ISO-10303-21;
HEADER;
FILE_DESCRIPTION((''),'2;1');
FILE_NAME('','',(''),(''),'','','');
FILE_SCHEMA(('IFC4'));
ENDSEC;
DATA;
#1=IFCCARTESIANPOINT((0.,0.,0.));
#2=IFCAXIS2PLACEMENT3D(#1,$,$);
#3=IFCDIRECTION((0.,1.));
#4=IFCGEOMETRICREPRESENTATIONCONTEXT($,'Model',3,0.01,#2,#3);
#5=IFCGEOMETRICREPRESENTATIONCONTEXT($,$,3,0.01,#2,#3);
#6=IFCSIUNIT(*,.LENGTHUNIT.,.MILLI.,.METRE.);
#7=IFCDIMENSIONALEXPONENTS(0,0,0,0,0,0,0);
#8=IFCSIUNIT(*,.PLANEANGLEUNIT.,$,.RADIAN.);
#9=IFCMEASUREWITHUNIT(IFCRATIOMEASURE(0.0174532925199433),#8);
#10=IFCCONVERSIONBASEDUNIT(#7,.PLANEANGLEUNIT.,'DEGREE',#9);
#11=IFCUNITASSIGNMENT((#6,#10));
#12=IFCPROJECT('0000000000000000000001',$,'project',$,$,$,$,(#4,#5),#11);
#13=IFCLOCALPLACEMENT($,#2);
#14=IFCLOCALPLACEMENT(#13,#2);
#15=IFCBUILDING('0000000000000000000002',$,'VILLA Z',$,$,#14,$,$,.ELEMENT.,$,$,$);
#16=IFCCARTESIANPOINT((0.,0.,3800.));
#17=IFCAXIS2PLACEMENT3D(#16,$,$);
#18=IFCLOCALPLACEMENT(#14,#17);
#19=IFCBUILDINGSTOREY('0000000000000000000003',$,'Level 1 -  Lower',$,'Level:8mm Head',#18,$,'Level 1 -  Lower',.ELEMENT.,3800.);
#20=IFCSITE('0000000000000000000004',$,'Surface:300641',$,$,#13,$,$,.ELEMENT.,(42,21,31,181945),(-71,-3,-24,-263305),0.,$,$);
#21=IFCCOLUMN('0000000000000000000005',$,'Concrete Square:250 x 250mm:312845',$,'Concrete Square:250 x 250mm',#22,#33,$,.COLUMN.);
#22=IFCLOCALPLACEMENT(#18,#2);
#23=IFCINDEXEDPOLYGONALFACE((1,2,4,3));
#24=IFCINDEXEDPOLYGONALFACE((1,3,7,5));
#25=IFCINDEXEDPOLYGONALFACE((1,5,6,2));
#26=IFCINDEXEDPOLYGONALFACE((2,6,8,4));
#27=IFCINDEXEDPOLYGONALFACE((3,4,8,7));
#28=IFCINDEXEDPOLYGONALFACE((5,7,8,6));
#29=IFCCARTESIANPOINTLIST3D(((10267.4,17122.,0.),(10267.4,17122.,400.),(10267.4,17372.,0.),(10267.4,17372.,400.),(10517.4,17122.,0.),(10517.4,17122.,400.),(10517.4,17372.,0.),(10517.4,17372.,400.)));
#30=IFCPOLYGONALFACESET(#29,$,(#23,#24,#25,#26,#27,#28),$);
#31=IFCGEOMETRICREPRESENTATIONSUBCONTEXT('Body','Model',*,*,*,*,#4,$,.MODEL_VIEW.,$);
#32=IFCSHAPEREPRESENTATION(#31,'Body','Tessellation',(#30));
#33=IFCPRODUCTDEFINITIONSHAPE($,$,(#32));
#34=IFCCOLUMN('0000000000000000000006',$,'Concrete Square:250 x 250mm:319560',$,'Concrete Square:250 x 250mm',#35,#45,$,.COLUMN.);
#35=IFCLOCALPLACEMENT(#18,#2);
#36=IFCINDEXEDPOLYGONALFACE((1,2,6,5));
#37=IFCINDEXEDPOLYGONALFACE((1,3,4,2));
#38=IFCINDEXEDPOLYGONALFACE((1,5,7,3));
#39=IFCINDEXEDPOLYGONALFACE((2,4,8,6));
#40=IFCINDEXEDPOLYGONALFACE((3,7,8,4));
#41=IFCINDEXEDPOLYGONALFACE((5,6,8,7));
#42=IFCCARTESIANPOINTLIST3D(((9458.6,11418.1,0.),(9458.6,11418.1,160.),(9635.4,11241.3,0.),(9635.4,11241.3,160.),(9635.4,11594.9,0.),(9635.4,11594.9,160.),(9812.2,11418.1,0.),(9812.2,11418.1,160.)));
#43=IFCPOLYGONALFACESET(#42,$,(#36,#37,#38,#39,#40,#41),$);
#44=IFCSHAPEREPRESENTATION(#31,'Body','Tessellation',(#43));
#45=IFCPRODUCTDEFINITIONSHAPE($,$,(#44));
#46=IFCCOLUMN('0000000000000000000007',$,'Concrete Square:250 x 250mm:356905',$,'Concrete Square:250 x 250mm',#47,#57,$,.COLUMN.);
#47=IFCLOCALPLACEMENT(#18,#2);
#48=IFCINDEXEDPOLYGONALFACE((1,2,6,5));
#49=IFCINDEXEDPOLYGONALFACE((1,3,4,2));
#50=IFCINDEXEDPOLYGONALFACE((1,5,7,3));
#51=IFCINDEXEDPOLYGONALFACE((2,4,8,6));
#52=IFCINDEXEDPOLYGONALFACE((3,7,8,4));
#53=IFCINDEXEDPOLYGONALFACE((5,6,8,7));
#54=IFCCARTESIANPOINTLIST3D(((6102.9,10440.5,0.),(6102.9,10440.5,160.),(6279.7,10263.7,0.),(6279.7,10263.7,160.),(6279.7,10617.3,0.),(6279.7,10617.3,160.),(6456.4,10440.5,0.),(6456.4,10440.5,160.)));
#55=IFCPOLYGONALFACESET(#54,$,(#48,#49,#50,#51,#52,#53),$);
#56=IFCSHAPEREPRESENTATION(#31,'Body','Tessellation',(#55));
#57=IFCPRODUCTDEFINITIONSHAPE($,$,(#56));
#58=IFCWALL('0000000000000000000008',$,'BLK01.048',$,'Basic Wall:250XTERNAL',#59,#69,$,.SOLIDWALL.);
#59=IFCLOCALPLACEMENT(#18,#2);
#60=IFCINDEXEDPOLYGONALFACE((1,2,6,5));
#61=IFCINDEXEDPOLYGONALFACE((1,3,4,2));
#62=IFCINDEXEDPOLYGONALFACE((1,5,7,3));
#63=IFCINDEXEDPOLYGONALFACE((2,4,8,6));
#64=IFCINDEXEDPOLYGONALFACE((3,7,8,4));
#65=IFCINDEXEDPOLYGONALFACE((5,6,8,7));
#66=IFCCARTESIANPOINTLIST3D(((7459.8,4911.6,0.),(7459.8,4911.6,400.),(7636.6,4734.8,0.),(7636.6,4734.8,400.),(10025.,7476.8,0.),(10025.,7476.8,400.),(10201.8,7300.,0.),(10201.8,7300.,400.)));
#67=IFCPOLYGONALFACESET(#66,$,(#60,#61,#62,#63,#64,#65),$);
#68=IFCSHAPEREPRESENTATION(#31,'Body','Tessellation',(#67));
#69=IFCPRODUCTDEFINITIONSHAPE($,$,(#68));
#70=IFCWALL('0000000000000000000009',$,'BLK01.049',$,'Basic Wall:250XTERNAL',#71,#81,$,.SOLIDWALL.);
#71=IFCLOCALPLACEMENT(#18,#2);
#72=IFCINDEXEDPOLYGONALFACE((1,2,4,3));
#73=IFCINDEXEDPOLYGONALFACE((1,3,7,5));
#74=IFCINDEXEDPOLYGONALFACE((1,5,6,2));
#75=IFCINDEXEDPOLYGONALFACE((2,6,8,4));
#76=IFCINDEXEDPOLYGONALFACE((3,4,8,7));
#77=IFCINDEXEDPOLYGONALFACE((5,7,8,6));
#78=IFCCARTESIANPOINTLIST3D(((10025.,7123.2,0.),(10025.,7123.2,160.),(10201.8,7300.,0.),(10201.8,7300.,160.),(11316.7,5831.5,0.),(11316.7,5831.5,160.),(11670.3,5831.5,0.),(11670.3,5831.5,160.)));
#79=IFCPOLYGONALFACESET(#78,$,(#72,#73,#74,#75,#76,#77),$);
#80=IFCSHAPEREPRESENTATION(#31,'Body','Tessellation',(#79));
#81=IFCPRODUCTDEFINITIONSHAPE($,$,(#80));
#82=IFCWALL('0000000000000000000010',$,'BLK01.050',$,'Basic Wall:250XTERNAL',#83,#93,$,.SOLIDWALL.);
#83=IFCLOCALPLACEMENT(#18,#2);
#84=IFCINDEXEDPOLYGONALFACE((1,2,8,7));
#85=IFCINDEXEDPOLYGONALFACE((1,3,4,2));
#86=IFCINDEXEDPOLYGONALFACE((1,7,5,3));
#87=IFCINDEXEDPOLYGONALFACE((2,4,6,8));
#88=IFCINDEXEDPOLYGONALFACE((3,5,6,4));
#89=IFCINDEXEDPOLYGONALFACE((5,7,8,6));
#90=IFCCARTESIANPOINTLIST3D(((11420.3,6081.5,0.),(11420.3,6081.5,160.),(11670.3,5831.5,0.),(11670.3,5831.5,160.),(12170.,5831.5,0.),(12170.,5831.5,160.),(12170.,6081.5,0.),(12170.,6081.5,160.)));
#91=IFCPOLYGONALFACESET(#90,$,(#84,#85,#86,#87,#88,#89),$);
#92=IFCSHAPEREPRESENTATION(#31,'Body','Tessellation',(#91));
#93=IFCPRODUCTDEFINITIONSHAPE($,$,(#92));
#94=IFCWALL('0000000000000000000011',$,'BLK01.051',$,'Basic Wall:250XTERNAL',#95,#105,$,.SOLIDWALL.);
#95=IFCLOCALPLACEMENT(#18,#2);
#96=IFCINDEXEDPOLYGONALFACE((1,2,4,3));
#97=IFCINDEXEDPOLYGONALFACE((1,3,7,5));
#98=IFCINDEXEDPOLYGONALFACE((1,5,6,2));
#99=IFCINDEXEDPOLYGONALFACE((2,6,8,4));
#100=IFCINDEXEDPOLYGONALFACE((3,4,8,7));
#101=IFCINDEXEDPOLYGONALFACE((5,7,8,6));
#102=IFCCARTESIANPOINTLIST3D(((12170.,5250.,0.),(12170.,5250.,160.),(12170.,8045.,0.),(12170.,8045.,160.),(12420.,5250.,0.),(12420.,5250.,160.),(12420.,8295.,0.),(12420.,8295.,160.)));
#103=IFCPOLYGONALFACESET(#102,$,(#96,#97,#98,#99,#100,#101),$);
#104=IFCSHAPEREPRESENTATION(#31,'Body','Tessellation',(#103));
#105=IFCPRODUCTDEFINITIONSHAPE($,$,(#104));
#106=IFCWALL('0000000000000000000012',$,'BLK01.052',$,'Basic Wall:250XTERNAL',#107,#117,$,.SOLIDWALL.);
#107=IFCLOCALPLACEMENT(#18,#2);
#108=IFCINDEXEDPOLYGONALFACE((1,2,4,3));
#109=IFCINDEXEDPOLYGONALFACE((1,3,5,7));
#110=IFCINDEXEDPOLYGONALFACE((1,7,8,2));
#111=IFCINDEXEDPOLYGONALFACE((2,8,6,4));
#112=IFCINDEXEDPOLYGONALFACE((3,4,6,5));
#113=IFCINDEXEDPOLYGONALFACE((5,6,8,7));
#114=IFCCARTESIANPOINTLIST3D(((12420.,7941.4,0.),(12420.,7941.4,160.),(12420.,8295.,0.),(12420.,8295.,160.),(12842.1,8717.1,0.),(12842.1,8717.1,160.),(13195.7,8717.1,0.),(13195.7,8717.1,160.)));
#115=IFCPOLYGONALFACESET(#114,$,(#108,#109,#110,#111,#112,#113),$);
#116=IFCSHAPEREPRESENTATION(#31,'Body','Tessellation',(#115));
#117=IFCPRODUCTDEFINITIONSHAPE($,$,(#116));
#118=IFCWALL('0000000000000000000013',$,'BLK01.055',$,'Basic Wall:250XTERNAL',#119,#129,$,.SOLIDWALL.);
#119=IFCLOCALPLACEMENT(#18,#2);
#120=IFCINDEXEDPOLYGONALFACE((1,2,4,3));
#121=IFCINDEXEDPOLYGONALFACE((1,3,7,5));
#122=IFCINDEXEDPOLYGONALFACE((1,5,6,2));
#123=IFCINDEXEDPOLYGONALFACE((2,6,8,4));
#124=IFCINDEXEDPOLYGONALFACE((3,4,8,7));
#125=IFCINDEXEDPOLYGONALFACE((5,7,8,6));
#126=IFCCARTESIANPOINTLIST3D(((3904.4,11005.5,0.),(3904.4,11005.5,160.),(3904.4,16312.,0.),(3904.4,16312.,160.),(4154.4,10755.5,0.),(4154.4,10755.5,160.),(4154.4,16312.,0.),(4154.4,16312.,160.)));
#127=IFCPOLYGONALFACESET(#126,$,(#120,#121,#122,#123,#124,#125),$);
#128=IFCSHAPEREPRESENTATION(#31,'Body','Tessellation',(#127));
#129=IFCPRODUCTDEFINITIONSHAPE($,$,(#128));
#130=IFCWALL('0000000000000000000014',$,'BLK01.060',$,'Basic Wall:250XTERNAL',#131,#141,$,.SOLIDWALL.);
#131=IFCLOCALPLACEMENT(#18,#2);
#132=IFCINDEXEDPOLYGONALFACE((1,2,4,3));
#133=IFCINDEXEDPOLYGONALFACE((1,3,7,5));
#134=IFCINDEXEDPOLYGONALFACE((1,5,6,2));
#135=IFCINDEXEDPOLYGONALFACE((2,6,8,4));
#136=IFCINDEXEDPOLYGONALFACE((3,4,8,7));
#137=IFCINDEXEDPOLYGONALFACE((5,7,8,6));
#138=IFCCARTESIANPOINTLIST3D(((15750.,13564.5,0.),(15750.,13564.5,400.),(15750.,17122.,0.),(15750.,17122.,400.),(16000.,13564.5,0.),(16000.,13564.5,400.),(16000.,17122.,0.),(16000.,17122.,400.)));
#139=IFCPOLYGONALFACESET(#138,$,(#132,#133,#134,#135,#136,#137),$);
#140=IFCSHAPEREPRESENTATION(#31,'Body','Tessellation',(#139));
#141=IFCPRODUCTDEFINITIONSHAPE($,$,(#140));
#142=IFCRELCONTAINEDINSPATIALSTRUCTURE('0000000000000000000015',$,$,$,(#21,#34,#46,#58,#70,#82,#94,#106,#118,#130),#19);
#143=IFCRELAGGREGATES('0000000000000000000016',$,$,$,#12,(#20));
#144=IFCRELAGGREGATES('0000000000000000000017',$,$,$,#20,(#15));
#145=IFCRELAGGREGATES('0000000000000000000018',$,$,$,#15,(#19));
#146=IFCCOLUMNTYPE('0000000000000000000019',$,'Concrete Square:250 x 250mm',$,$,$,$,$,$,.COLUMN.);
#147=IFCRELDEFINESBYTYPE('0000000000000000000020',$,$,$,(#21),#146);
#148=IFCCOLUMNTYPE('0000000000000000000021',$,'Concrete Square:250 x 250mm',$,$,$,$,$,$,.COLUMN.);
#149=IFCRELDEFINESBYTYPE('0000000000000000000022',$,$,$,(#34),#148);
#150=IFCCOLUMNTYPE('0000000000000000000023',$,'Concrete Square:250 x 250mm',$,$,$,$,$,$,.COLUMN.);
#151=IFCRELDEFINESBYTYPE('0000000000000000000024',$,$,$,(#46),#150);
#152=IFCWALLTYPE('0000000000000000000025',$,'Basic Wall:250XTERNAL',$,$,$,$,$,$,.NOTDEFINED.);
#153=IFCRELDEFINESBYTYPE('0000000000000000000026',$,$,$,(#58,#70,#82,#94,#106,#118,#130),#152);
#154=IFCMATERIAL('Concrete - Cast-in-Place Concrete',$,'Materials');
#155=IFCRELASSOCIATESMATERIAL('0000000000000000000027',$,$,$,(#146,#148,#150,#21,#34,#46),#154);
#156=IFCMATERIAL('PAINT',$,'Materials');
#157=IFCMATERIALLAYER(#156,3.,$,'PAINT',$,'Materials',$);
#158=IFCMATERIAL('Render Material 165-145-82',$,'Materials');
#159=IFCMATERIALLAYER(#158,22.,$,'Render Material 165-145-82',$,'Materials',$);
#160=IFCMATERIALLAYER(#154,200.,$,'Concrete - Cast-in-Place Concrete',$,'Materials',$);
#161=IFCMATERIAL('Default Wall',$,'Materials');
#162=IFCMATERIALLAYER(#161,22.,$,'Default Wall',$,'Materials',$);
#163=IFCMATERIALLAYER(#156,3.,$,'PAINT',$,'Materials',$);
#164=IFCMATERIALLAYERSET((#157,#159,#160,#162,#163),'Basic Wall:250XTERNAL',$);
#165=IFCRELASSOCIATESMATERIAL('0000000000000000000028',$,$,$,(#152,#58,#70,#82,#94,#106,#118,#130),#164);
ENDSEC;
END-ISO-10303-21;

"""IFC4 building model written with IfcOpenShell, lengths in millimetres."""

from ifc_helpers import new_model, entity, si_unit, converted_unit, direction, frame, frame_2d, origin, origin_2d_with_axis, place, context, subcontext, project, spatial, polyline, rectangle, outline, extrude, clip, halfspace, bounded_halfspace, source, transform, mapped, material, layer, layer_set, layer_usage, material_profile, profile_set, profile_usage, type_object, type_shapes, element, save


model = new_model("IFC4")

# Units and contexts
model_context = context("Model", 3, precision=0.01, world=origin(), true_north=direction((0.0, 1.0)))
context_of_model = context(None, 3, precision=0.01, world=origin(), true_north=direction((0.0, 1.0)))
body_context = subcontext(model_context, "Body", "Model", "MODEL_VIEW")
ifc_project = project(units=[si_unit("LENGTHUNIT", "METRE", prefix="MILLI"), converted_unit("PLANEANGLEUNIT", "DEGREE", entity("IfcRatioMeasure", 0.0174532925199433), si_unit("PLANEANGLEUNIT", "RADIAN"), dimensions=[0, 0, 0, 0, 0, 0, 0])], contexts=[model_context, context_of_model])

# Site, building, storey
site_placement = place(None, origin())
site = spatial("IfcSite", under=ifc_project, at=site_placement, Name="Surface:300641", CompositionType="ELEMENT", RefLatitude=(42, 21, 31, 181945), RefLongitude=(-71, -3, -24, -263305), RefElevation=0.0)
building_placement = place(site_placement, origin())
building = spatial("IfcBuilding", under=site, at=building_placement, Name="VILLA Z", CompositionType="ELEMENT")
storey_placement = place(building_placement, frame((0.0, 0.0, 3800.0)))
storey = spatial("IfcBuildingStorey", under=building, at=storey_placement, Name="Level 1 -  Lower", ObjectType="Level:8mm Head", LongName="Level 1 -  Lower", CompositionType="ELEMENT", Elevation=3800.0)

# Columns
ifc_material_1 = material(Name="Concrete - Cast-in-Place Concrete", Category="Materials")
ifc_material_profile_1 = material_profile(ifc_material_1, rectangle(XDim=250.0, YDim=250.0, at=frame_2d((0.0, 0.0), x_axis=(1.0, 0.0))), Name="250 x 250mm")
ifc_profile_set_1 = profile_set([ifc_material_profile_1], Name="250 x 250mm")
ifc_profile_usage_1 = profile_usage(ifc_profile_set_1)
column_type_1 = type_object("IfcColumnType", Name="Concrete Square:250 x 250mm", PredefinedType="COLUMN", material=ifc_profile_set_1)
shared_shape_1 = source(origin(), body_context, "Body", "SweptSolid", [
    extrude(rectangle(XDim=250.0, YDim=250.0, at=origin_2d_with_axis()), frame((10392.4, 17247.0, 3800.0), z_axis=(0.0, 0.0, 1.0), x_axis=(0.0, -1.0, 0.0)), (0.0, 0.0, 1.0), 400.0),
])
type_shapes(column_type_1, [shared_shape_1])
column_1_placement = place(storey_placement, frame((0.0, 0.0, -3800.0)))
element("IfcColumn", 1, at=column_1_placement, inside=storey, type_object=column_type_1, material=ifc_profile_usage_1, Name="Concrete Square:250 x 250mm:312845", ObjectType="Concrete Square:250 x 250mm", PredefinedType="COLUMN", context=body_context, shape_type="MappedRepresentation", body=[
    mapped(shared_shape_1, transform((0.0, 0.0, 0.0), scale=1.0)),
])
ifc_profile_usage_2 = profile_usage(ifc_profile_set_1)
column_type_2 = type_object("IfcColumnType", Name="Concrete Square:250 x 250mm", PredefinedType="COLUMN", material=ifc_profile_set_1)
shared_shape_2 = source(origin(), body_context, "Body", "SweptSolid", [
    extrude(rectangle(XDim=250.0, YDim=250.0, at=frame_2d((0.0, 0.0), x_axis=(1.0, 0.0))), frame((9635.4, 11418.1, 3800.0), z_axis=(0.0, 0.0, 1.0), x_axis=(-0.707107, 0.707107, 0.0)), (0.0, 0.0, 1.0), 160.0),
])
type_shapes(column_type_2, [shared_shape_2])
column_2_placement = place(storey_placement, frame((0.0, 0.0, -3800.0)))
element("IfcColumn", 2, at=column_2_placement, inside=storey, type_object=column_type_2, material=ifc_profile_usage_2, Name="Concrete Square:250 x 250mm:319560", ObjectType="Concrete Square:250 x 250mm", PredefinedType="COLUMN", context=body_context, shape_type="MappedRepresentation", body=[
    mapped(shared_shape_2, transform((0.0, 0.0, 0.0), scale=1.0)),
])
ifc_profile_usage_3 = profile_usage(ifc_profile_set_1)
column_type_3 = type_object("IfcColumnType", Name="Concrete Square:250 x 250mm", PredefinedType="COLUMN", material=ifc_profile_set_1)
shared_shape_3 = source(origin(), body_context, "Body", "SweptSolid", [
    extrude(rectangle(XDim=250.0, YDim=250.0, at=origin_2d_with_axis()), frame((6279.7, 10440.5, 3800.0), z_axis=(0.0, 0.0, 1.0), x_axis=(-0.707107, 0.707107, 0.0)), (0.0, 0.0, 1.0), 160.0),
])
type_shapes(column_type_3, [shared_shape_3])
column_3_placement = place(storey_placement, frame((0.0, 0.0, -3800.0)))
element("IfcColumn", 3, at=column_3_placement, inside=storey, type_object=column_type_3, material=ifc_profile_usage_3, Name="Concrete Square:250 x 250mm:356905", ObjectType="Concrete Square:250 x 250mm", PredefinedType="COLUMN", context=body_context, shape_type="MappedRepresentation", body=[
    mapped(shared_shape_3, transform((0.0, 0.0, 0.0), scale=1.0)),
])

# Walls
ifc_material_2 = material(Name="PAINT", Category="Materials")
ifc_layer_1 = layer(ifc_material_2, 3.0, Name="PAINT", Category="Materials")
ifc_material_3 = material(Name="Render Material 165-145-82", Category="Materials")
ifc_layer_2 = layer(ifc_material_3, 22.0, Name="Render Material 165-145-82", Category="Materials")
ifc_layer_3 = layer(ifc_material_1, 200.0, Name="Concrete - Cast-in-Place Concrete", Category="Materials")
ifc_material_4 = material(Name="Default Wall", Category="Materials")
ifc_layer_4 = layer(ifc_material_4, 22.0, Name="Default Wall", Category="Materials")
ifc_layer_5 = layer(ifc_material_2, 3.0, Name="PAINT", Category="Materials")
ifc_layer_set_1 = layer_set([ifc_layer_1, ifc_layer_2, ifc_layer_3, ifc_layer_4, ifc_layer_5], Name="Basic Wall:250XTERNAL")
wall_type_1 = type_object("IfcWallType", Name="Basic Wall:250XTERNAL", PredefinedType="NOTDEFINED", material=ifc_layer_set_1)
ifc_layer_usage_1 = layer_usage(ifc_layer_set_1, "AXIS2", "NEGATIVE", 125.0)
wall_1_placement = place(storey_placement, frame((7548.2, 4823.2, 0.0), z_axis=(0.0, 0.0, 1.0), x_axis=(0.707107, 0.707107, 0.0)))
element("IfcWall", 4, at=wall_1_placement, inside=storey, type_object=wall_type_1, material=ifc_layer_usage_1, Name="BLK01.048", ObjectType="Basic Wall:250XTERNAL", PredefinedType="SOLIDWALL", context=body_context, shape_type="Clipping", body=[
    clip(extrude(rectangle(XDim=3627.7, YDim=250.0, at=frame_2d((1813.8, 0.0), x_axis=(-1.0, 0.0))), origin(), (0.0, 0.0, 1.0), 400.0), halfspace(frame((0.0, 0.0, -3200.0)), True)),
])
ifc_layer_usage_2 = layer_usage(ifc_layer_set_1, "AXIS2", "NEGATIVE", 125.0)
wall_2_placement = place(storey_placement, frame((10113.4, 7211.6, 0.0), z_axis=(0.0, 0.0, 1.0), x_axis=(0.707107, -0.707107, 0.0)))
element("IfcWall", 5, at=wall_2_placement, inside=storey, type_object=wall_type_1, material=ifc_layer_usage_2, Name="BLK01.049", ObjectType="Basic Wall:250XTERNAL", PredefinedType="SOLIDWALL", context=body_context, shape_type="Clipping", body=[
    clip(clip(extrude(outline(polyline([(0.0, -125.0), (1826.8, -125.0), (2076.8, 125.0), (1723.2, 125.0), (0.0, 125.0), (0.0, -125.0)])), origin(), (0.0, 0.0, 1.0), 160.0), bounded_halfspace(frame((0.0, -125.0, 160.0), z_axis=(0.0, 0.0, -1.0), x_axis=(0.707107, -0.707107, 0.0)), True, frame((0.0, -125.0, 160.0)), polyline([(0.0, 0.0), (1826.8, 0.0), (2076.8, 250.0), (1723.2, 250.0), (0.0, 250.0), (0.0, 0.0)]))), halfspace(frame((0.0, 0.0, -3200.0)), True)),
])
ifc_layer_usage_3 = layer_usage(ifc_layer_set_1, "AXIS2", "NEGATIVE", 125.0)
wall_3_placement = place(storey_placement, frame((11420.3, 5956.5, 0.0)))
element("IfcWall", 6, at=wall_3_placement, inside=storey, type_object=wall_type_1, material=ifc_layer_usage_3, Name="BLK01.050", ObjectType="Basic Wall:250XTERNAL", PredefinedType="SOLIDWALL", context=body_context, shape_type="Clipping", body=[
    clip(clip(extrude(outline(polyline([(749.7, -125.0), (749.7, 125.0), (0.0, 125.0), (250.0, -125.0), (749.7, -125.0)])), origin(), (0.0, 0.0, 1.0), 160.0), bounded_halfspace(frame((250.0, -125.0, 160.0), z_axis=(0.0, 0.0, -1.0), x_axis=(0.0, -1.0, 0.0)), True, frame((250.0, -125.0, 160.0)), polyline([(0.0, 0.0), (499.7, 0.0), (499.7, 250.0), (-250.0, 250.0), (0.0, 0.0)]))), halfspace(frame((0.0, 0.0, -3200.0)), True)),
])
ifc_layer_usage_4 = layer_usage(ifc_layer_set_1, "AXIS2", "NEGATIVE", 125.0)
wall_4_placement = place(storey_placement, frame((12295.0, 5250.0, 0.0), z_axis=(0.0, 0.0, 1.0), x_axis=(0.0, 1.0, 0.0)))
element("IfcWall", 7, at=wall_4_placement, inside=storey, type_object=wall_type_1, material=ifc_layer_usage_4, Name="BLK01.051", ObjectType="Basic Wall:250XTERNAL", PredefinedType="SOLIDWALL", context=body_context, shape_type="Clipping", body=[
    clip(clip(extrude(outline(polyline([(3045.0, -125.0), (2795.0, 125.0), (831.5, 125.0), (581.5, 125.0), (0.0, 125.0), (0.0, -125.0), (2691.4, -125.0), (3045.0, -125.0)])), origin(), (0.0, 0.0, 1.0), 160.0), bounded_halfspace(frame((0.0, -125.0, 160.0), z_axis=(0.0, 0.0, -1.0), x_axis=(-1.0, 0.0, 0.0)), True, frame((0.0, -125.0, 160.0)), polyline([(0.0, 0.0), (2691.4, 0.0), (3045.0, 0.0), (2795.0, 250.0), (831.5, 250.0), (581.5, 250.0), (0.0, 250.0), (0.0, 0.0)]))), halfspace(frame((0.0, 0.0, -3200.0)), True)),
])
ifc_layer_usage_5 = layer_usage(ifc_layer_set_1, "AXIS2", "NEGATIVE", 125.0)
wall_5_placement = place(storey_placement, frame((12331.6, 8029.8, 0.0), z_axis=(0.0, 0.0, 1.0), x_axis=(0.707107, 0.707107, 0.0)))
element("IfcWall", 8, at=wall_5_placement, inside=storey, type_object=wall_type_1, material=ifc_layer_usage_5, Name="BLK01.052", ObjectType="Basic Wall:250XTERNAL", PredefinedType="SOLIDWALL", context=body_context, shape_type="Clipping", body=[
    clip(clip(extrude(outline(polyline([(1097.0, -125.0), (847.0, 125.0), (250.0, 125.0), (0.0, -125.0), (1097.0, -125.0)])), origin(), (0.0, 0.0, 1.0), 160.0), bounded_halfspace(frame((0.0, -125.0, 160.0), z_axis=(0.0, 0.0, -1.0), x_axis=(-0.707107, -0.707107, 0.0)), True, frame((0.0, -125.0, 160.0)), polyline([(0.0, 0.0), (1097.0, 0.0), (847.0, 250.0), (250.0, 250.0), (0.0, 0.0)]))), halfspace(frame((0.0, 0.0, -3200.0)), True)),
])
ifc_layer_usage_6 = layer_usage(ifc_layer_set_1, "AXIS2", "NEGATIVE", 125.0)
wall_6_placement = place(storey_placement, frame((4029.4, 10755.5, 0.0), z_axis=(0.0, 0.0, 1.0), x_axis=(0.0, 1.0, 0.0)))
element("IfcWall", 9, at=wall_6_placement, inside=storey, type_object=wall_type_1, material=ifc_layer_usage_6, Name="BLK01.055", ObjectType="Basic Wall:250XTERNAL", PredefinedType="SOLIDWALL", context=body_context, shape_type="Clipping", body=[
    clip(clip(extrude(outline(polyline([(5556.5, -125.0), (5556.5, 125.0), (250.0, 125.0), (0.0, -125.0), (5306.5, -125.0), (5556.5, -125.0)])), origin(), (0.0, 0.0, 1.0), 160.0), bounded_halfspace(frame((0.0, -125.0, 160.0), z_axis=(0.0, 0.0, -1.0), x_axis=(-1.0, 0.0, 0.0)), True, frame((0.0, -125.0, 160.0)), polyline([(0.0, 0.0), (5306.5, 0.0), (5531.5, 0.0), (5531.5, 225.0), (225.0, 225.0), (0.0, 0.0)]))), halfspace(frame((0.0, 0.0, -3200.0)), True)),
])

# Wall
ifc_layer_usage_7 = layer_usage(ifc_layer_set_1, "AXIS2", "NEGATIVE", 125.0)
wall_7_placement = place(storey_placement, frame((15875.0, 17122.0, 0.0), z_axis=(0.0, 0.0, 1.0), x_axis=(0.0, -1.0, 0.0)))
element("IfcWall", 10, at=wall_7_placement, inside=storey, type_object=wall_type_1, material=ifc_layer_usage_7, Name="BLK01.060", ObjectType="Basic Wall:250XTERNAL", PredefinedType="SOLIDWALL", context=body_context, shape_type="Clipping", body=[
    clip(extrude(rectangle(XDim=3557.5, YDim=250.0, at=frame_2d((1778.8, 0.0), x_axis=(-1.0, 0.0))), origin(), (0.0, 0.0, 1.0), 400.0), halfspace(origin(), True)),
])

save(model, "model.ifc")
